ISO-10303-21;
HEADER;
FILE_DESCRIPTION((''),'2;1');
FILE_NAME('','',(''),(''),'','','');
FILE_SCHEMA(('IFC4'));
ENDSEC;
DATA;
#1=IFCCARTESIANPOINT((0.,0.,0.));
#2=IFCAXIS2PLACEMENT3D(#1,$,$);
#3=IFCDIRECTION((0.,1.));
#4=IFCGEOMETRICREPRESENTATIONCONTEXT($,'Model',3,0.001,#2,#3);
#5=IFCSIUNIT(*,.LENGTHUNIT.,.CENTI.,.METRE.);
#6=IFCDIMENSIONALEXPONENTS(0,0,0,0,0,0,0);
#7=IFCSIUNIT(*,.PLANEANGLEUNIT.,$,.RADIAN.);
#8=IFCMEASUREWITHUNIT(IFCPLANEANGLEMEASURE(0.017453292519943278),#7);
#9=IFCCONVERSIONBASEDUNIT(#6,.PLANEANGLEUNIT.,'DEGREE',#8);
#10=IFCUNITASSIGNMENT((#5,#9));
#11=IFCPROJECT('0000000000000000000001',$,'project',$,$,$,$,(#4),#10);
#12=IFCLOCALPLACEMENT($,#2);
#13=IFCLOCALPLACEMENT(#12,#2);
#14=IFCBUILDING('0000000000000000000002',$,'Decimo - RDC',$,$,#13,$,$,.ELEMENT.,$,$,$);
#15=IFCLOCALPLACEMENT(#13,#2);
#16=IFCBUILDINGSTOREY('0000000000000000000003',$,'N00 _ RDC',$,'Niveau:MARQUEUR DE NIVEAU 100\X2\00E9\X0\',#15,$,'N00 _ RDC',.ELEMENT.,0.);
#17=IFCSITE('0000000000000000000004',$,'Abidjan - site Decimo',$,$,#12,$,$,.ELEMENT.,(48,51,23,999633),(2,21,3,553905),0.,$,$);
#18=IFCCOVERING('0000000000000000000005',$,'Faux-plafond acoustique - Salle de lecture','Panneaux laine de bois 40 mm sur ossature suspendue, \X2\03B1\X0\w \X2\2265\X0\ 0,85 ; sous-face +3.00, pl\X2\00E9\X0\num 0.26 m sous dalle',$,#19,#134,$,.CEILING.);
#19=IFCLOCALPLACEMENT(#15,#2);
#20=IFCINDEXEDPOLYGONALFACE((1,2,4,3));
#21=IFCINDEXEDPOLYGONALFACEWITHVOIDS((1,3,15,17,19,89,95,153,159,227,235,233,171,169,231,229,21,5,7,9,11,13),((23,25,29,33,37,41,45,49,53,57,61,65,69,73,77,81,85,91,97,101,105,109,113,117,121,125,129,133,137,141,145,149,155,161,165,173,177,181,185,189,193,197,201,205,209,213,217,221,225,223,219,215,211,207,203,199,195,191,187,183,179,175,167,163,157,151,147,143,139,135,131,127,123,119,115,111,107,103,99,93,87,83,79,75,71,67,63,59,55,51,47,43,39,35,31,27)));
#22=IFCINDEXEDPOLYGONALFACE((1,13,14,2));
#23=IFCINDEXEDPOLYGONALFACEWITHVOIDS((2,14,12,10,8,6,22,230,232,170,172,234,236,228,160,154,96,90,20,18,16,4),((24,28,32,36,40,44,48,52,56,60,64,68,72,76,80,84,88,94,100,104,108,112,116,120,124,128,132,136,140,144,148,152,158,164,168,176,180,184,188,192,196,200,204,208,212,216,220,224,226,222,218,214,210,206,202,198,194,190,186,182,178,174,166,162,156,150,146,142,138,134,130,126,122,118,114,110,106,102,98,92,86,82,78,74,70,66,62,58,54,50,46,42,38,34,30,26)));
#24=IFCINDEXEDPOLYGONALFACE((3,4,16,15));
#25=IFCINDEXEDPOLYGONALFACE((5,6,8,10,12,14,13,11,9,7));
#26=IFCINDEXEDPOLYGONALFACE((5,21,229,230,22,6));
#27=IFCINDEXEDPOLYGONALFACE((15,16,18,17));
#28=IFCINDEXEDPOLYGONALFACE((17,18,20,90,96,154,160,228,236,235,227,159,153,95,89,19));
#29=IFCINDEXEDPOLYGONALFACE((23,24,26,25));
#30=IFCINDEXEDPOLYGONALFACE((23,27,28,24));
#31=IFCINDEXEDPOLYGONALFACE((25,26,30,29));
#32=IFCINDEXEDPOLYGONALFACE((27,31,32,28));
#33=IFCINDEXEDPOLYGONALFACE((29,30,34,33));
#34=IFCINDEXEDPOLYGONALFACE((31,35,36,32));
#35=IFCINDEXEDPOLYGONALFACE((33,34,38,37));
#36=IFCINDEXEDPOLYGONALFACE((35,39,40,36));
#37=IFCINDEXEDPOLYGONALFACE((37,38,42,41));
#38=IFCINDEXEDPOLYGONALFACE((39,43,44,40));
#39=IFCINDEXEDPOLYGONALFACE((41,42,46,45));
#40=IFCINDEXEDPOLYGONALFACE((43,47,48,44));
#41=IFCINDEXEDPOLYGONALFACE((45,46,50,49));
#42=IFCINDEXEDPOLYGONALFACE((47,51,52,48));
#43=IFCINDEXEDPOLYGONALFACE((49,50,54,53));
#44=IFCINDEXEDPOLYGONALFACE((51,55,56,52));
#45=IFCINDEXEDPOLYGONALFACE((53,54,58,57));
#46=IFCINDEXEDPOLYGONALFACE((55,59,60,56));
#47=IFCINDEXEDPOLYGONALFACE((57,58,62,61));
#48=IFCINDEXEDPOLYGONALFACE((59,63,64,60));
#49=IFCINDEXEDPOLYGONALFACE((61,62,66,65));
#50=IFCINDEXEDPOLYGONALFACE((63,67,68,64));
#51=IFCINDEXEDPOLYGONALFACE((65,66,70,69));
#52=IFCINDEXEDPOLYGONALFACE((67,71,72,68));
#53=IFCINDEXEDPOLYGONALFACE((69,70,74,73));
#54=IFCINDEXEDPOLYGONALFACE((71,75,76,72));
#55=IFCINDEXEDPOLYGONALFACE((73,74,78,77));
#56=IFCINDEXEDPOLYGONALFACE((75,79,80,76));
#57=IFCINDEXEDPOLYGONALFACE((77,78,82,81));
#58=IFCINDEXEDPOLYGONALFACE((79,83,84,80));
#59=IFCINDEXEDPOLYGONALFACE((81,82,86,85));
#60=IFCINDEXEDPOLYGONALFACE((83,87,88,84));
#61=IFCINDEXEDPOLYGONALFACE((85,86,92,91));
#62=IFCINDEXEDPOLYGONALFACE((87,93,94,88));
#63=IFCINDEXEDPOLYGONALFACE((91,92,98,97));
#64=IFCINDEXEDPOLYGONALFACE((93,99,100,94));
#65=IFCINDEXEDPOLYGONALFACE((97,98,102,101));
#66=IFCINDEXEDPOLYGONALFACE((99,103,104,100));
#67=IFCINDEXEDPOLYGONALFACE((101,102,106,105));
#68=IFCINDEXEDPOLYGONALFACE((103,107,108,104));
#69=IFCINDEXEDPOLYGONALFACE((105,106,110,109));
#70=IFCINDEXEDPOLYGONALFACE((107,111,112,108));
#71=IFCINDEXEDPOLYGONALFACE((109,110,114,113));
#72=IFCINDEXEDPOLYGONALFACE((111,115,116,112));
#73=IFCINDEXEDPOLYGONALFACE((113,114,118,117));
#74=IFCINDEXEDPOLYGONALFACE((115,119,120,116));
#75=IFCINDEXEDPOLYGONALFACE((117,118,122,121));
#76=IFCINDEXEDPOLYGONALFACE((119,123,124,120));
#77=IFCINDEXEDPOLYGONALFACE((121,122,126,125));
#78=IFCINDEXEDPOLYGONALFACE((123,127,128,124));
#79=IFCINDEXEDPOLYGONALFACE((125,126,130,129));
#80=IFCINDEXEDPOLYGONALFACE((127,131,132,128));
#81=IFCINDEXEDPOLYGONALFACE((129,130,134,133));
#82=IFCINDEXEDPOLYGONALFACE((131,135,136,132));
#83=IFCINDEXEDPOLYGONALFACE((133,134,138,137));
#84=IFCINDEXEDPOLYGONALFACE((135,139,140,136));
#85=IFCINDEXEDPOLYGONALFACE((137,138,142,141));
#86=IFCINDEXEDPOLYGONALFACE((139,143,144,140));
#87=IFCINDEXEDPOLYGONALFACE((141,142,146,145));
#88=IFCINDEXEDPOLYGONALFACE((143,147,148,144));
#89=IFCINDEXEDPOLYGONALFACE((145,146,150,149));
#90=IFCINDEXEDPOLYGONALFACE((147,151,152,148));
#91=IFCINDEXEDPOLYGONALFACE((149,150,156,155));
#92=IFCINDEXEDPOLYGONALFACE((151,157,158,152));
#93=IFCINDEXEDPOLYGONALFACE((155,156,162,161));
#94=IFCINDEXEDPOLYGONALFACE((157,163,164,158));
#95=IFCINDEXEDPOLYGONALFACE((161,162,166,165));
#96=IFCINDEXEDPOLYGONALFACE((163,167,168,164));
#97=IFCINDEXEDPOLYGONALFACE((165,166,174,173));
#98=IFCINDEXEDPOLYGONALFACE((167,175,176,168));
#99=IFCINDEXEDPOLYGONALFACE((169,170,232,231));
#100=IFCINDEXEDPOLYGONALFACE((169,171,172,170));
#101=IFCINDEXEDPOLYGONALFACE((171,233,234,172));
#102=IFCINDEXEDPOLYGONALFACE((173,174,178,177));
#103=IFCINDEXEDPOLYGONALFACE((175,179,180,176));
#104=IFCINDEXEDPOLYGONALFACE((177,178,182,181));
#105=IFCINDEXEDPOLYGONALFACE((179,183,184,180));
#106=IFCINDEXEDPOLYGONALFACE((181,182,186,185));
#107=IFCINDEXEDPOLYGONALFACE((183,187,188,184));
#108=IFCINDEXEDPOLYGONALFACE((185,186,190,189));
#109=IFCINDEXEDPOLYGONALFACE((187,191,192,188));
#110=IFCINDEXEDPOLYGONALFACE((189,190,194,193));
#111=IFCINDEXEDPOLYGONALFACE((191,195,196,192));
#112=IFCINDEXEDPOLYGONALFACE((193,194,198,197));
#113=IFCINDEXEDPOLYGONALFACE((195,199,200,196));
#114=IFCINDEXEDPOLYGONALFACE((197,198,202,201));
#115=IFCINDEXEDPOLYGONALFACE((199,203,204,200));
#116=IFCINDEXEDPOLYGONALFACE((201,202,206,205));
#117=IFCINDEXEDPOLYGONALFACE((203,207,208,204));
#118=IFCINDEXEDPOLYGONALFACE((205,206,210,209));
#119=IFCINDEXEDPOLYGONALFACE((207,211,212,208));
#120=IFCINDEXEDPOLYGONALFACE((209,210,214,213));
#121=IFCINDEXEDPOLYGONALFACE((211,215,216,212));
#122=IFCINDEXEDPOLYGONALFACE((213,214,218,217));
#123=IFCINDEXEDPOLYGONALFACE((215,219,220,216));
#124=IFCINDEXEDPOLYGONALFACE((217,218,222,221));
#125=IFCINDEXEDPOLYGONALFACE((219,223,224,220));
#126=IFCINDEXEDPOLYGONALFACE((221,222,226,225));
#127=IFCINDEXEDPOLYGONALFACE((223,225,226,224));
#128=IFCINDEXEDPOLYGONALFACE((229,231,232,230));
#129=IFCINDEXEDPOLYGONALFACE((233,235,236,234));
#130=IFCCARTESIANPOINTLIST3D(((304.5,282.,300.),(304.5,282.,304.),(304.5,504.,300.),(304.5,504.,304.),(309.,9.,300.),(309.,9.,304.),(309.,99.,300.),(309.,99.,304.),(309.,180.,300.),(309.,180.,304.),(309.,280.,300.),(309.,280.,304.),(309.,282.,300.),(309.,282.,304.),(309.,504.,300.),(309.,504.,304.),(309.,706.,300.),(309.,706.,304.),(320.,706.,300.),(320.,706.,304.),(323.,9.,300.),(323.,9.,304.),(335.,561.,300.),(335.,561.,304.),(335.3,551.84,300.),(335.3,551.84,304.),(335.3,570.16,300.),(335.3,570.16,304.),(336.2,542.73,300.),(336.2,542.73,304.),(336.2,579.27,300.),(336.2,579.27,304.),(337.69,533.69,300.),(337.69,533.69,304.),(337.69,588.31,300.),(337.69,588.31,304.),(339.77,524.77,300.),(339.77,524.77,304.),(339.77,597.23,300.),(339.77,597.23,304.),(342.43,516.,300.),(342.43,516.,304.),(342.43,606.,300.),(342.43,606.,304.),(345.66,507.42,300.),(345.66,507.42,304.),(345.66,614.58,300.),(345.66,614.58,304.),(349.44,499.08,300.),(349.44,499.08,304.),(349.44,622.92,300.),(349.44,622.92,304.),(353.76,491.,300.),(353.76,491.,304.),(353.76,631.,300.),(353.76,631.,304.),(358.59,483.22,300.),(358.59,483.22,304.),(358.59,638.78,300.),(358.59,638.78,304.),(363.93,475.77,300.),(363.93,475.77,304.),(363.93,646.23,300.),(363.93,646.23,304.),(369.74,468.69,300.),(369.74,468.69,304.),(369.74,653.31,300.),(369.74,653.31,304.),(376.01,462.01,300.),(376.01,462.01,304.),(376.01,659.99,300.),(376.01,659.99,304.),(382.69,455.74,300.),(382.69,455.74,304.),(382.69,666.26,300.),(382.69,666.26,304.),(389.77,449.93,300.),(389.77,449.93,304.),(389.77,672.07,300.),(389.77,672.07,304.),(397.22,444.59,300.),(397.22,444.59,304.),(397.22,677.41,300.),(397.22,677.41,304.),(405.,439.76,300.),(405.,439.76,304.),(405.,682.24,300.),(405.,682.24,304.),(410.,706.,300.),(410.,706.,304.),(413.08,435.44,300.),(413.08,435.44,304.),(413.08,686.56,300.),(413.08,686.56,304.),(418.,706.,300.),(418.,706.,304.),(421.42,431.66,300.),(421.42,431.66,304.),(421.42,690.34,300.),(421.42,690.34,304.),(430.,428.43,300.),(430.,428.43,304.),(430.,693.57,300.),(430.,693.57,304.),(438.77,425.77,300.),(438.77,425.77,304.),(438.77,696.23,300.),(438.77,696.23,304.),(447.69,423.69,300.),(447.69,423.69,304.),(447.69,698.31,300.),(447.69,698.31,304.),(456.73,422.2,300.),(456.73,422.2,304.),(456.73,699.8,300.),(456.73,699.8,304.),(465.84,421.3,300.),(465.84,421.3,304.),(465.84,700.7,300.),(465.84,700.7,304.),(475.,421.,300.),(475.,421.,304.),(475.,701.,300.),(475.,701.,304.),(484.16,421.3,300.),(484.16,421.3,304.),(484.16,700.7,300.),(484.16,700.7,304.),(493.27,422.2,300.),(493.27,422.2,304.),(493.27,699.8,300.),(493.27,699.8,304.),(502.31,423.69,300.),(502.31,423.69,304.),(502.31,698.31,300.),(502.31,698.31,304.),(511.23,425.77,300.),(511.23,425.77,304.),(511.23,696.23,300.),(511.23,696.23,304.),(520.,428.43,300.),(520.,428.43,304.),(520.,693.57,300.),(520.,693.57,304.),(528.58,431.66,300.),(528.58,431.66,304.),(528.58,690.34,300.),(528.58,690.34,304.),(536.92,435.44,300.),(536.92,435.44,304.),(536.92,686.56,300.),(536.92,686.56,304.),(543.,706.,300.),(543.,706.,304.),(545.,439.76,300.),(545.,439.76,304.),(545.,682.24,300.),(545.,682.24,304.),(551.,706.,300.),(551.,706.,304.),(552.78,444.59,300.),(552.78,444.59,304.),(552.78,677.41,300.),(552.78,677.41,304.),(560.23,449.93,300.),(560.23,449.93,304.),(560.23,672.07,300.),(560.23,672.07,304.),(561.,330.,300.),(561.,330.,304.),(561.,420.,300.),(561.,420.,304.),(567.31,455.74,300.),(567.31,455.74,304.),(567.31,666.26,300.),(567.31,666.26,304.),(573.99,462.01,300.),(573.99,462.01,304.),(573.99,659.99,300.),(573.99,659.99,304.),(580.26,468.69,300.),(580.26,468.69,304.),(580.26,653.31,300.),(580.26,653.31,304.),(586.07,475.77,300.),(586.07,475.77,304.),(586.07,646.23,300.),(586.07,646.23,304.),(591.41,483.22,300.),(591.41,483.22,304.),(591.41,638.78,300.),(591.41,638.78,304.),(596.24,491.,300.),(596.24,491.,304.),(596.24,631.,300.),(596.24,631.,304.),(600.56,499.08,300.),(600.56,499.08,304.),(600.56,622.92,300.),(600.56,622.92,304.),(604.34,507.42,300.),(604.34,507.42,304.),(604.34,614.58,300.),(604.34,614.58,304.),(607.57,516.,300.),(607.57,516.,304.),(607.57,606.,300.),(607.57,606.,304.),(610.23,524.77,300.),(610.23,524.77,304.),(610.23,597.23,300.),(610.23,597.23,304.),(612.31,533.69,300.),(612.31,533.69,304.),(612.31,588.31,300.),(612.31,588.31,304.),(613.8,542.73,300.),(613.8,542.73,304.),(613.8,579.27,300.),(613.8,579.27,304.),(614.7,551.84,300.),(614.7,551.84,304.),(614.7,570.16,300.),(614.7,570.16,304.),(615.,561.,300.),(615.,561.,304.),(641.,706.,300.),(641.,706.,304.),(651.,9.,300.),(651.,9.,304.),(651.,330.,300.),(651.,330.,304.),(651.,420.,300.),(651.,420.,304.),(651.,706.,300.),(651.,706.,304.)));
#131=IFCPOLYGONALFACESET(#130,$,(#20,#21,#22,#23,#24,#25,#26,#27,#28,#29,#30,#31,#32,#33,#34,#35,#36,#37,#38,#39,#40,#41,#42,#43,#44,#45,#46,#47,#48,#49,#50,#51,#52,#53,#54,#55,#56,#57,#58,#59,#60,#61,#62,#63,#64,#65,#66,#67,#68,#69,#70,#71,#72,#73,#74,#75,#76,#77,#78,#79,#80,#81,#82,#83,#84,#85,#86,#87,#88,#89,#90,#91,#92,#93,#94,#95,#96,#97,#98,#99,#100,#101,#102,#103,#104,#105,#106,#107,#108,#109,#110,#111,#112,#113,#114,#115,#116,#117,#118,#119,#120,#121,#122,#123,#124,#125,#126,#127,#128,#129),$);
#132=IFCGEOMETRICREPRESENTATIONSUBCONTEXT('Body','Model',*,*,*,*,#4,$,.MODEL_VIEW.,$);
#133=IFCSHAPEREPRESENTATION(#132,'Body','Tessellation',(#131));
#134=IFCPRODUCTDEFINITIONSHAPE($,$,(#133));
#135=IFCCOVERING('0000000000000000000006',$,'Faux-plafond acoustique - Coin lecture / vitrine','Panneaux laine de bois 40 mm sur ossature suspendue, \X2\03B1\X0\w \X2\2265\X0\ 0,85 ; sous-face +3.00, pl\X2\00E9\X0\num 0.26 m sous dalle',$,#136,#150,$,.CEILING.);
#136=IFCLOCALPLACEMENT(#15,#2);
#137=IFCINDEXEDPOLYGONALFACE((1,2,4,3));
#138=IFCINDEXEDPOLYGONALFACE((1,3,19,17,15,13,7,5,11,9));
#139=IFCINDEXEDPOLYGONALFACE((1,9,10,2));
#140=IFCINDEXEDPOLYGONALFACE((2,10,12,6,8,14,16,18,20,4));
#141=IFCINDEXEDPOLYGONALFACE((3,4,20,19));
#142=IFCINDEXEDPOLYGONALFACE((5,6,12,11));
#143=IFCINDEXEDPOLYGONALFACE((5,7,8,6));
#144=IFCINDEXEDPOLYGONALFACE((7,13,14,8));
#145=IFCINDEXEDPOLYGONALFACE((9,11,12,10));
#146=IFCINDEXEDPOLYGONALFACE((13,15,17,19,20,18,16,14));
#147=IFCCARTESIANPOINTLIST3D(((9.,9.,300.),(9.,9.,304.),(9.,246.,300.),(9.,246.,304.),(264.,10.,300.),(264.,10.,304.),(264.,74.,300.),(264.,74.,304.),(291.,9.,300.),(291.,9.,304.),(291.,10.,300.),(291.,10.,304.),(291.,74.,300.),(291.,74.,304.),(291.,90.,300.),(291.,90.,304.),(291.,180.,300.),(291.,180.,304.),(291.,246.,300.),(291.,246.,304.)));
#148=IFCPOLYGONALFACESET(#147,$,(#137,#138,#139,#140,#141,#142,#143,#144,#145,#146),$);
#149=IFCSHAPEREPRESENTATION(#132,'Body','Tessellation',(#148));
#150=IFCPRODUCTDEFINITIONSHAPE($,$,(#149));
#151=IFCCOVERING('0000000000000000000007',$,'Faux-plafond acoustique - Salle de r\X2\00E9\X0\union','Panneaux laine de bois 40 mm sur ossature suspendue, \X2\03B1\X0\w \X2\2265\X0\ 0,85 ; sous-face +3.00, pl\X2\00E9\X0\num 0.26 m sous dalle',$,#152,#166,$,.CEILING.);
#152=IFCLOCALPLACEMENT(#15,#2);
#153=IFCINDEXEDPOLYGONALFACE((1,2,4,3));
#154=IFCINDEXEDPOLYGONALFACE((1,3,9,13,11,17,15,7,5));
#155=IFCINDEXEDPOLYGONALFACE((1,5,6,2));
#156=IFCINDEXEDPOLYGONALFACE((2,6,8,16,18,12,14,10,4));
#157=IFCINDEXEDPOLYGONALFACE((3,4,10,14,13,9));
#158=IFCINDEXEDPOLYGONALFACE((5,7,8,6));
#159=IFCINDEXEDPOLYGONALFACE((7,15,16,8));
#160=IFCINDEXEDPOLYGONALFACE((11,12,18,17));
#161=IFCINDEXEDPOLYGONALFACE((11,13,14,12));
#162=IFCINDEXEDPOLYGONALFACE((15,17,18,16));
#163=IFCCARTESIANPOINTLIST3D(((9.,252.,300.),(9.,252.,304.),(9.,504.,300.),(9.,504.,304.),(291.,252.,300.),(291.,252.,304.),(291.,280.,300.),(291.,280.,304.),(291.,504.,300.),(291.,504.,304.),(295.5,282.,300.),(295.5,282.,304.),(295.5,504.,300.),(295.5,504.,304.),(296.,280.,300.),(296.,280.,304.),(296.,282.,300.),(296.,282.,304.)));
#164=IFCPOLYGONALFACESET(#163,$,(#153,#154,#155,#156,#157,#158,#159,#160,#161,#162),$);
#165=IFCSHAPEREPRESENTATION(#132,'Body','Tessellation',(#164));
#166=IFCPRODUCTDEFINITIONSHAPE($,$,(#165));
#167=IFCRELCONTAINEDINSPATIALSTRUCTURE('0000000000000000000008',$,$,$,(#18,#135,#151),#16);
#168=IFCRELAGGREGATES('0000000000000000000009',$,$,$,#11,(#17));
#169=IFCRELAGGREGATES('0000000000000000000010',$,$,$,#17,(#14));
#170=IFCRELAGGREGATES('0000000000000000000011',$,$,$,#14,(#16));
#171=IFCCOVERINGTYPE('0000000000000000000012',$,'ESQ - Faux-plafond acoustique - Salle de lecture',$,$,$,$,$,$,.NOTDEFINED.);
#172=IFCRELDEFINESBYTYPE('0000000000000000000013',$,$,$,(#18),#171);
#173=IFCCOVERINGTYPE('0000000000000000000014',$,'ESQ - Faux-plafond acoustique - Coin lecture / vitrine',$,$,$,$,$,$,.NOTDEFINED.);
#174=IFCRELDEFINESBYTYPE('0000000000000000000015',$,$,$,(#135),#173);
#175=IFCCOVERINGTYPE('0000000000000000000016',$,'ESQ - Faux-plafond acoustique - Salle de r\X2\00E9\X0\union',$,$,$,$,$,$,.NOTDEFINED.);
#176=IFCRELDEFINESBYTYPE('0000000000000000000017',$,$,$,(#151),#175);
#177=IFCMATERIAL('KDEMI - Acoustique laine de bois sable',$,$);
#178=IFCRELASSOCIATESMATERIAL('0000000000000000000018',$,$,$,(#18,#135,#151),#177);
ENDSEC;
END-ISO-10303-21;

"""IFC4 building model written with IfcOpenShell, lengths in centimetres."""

from ifc_helpers import new_model, entity, si_unit, converted_unit, direction, frame, origin, origin_with_axes, place, context, subcontext, project, spatial, polyline, outline, extrude, material, type_object, element, save


model = new_model("IFC4")

# Units and contexts
model_context = context("Model", 3, precision=0.001, world=origin(), true_north=direction((0.0, 1.0)))
body_context = subcontext(model_context, "Body", "Model", "MODEL_VIEW")
ifc_project = project(units=[si_unit("LENGTHUNIT", "METRE", prefix="CENTI"), converted_unit("PLANEANGLEUNIT", "DEGREE", entity("IfcPlaneAngleMeasure", 0.017453292519943278), si_unit("PLANEANGLEUNIT", "RADIAN"), dimensions=[0, 0, 0, 0, 0, 0, 0])], contexts=[model_context])

# Site, building, storey
site_placement = place(None, origin())
site = spatial("IfcSite", under=ifc_project, at=site_placement, Name="Abidjan - site Decimo", CompositionType="ELEMENT", RefLatitude=(48, 51, 23, 999633), RefLongitude=(2, 21, 3, 553905), RefElevation=0.0)
building_placement = place(site_placement, origin())
building = spatial("IfcBuilding", under=site, at=building_placement, Name="Decimo - RDC", CompositionType="ELEMENT")
storey_placement = place(building_placement, origin())
storey = spatial("IfcBuildingStorey", under=building, at=storey_placement, Name="N00 _ RDC", ObjectType="Niveau:MARQUEUR DE NIVEAU 100é", LongName="N00 _ RDC", CompositionType="ELEMENT", Elevation=0.0)

# Coverings
ifc_material_1 = material(Name="KDEMI - Acoustique laine de bois sable")
covering_type_1 = type_object("IfcCoveringType", Name="ESQ - Faux-plafond acoustique - Salle de lecture", PredefinedType="NOTDEFINED")
covering_1_placement = place(storey_placement, origin_with_axes())
element("IfcCovering", 1, at=covering_1_placement, inside=storey, type_object=covering_type_1, material=ifc_material_1, Name="Faux-plafond acoustique - Salle de lecture", Description="Panneaux laine de bois 40 mm sur ossature suspendue, αw ≥ 0,85 ; sous-face +3.00, plénum 0.26 m sous dalle", PredefinedType="CEILING", context=body_context, shape_type="SweptSolid", body=[
    extrude(outline(polyline([(651.0, 706.0), (651.0, 420.0), (561.0, 420.0), (561.0, 330.0), (651.0, 330.0), (651.0, 9.0), (651.0, 9.0), (651.0, 9.0), (323.0, 9.0), (323.0, 9.0), (309.0, 9.0), (309.0, 99.0), (309.0, 180.0), (309.0, 180.0), (309.0, 280.0), (309.0, 280.0), (309.0, 282.0), (304.0, 282.0), (304.0, 282.0), (304.5, 282.0), (304.5, 504.0), (309.0, 504.0), (309.0, 504.0), (309.0, 706.0), (320.0, 706.0), (410.0, 706.0), (418.0, 706.0), (543.0, 706.0), (551.0, 706.0), (641.0, 706.0), (651.0, 706.0)]), holes=[polyline([(610.23, 597.23), (607.57, 606.0), (604.34, 614.58), (600.56, 622.92), (596.24, 631.0), (591.41, 638.78), (586.07, 646.23), (580.26, 653.31), (573.99, 659.99), (567.31, 666.26), (560.23, 672.07), (552.78, 677.41), (545.0, 682.24), (536.92, 686.56), (528.58, 690.34), (520.0, 693.57), (511.23, 696.23), (502.31, 698.31), (493.27, 699.8), (484.16, 700.7), (475.0, 701.0), (465.84, 700.7), (456.73, 699.8), (447.69, 698.31), (438.77, 696.23), (430.0, 693.57), (421.42, 690.34), (413.08, 686.56), (405.0, 682.24), (397.22, 677.41), (389.77, 672.07), (382.69, 666.26), (376.01, 659.99), (369.74, 653.31), (363.93, 646.23), (358.59, 638.78), (353.76, 631.0), (349.44, 622.92), (345.66, 614.58), (342.43, 606.0), (339.77, 597.23), (337.69, 588.31), (336.2, 579.27), (335.3, 570.16), (335.0, 561.0), (335.3, 551.84), (336.2, 542.73), (337.69, 533.69), (339.77, 524.77), (342.43, 516.0), (345.66, 507.42), (349.44, 499.08), (353.76, 491.0), (358.59, 483.22), (363.93, 475.77), (369.74, 468.69), (376.01, 462.01), (382.69, 455.74), (389.77, 449.93), (397.22, 444.59), (405.0, 439.76), (413.08, 435.44), (421.42, 431.66), (430.0, 428.43), (438.77, 425.77), (447.69, 423.69), (456.73, 422.2), (465.84, 421.3), (475.0, 421.0), (484.16, 421.3), (493.27, 422.2), (502.31, 423.69), (511.23, 425.77), (520.0, 428.43), (528.58, 431.66), (536.92, 435.44), (545.0, 439.76), (552.78, 444.59), (560.23, 449.93), (567.31, 455.74), (573.99, 462.01), (580.26, 468.69), (586.07, 475.77), (591.41, 483.22), (596.24, 491.0), (600.56, 499.08), (604.34, 507.42), (607.57, 516.0), (610.23, 524.77), (612.31, 533.69), (613.8, 542.73), (614.7, 551.84), (615.0, 561.0), (614.7, 570.16), (613.8, 579.27), (612.31, 588.31), (610.23, 597.23)])]), frame((0.0, 0.0, 300.0)), (0.0, 0.0, 1.0), 4.0),
])
covering_type_2 = type_object("IfcCoveringType", Name="ESQ - Faux-plafond acoustique - Coin lecture / vitrine", PredefinedType="NOTDEFINED")
covering_2_placement = place(storey_placement, origin_with_axes())
element("IfcCovering", 2, at=covering_2_placement, inside=storey, type_object=covering_type_2, material=ifc_material_1, Name="Faux-plafond acoustique - Coin lecture / vitrine", Description="Panneaux laine de bois 40 mm sur ossature suspendue, αw ≥ 0,85 ; sous-face +3.00, plénum 0.26 m sous dalle", PredefinedType="CEILING", context=body_context, shape_type="SweptSolid", body=[
    extrude(outline(polyline([(291.0, 90.0), (291.0, 74.0), (264.0, 74.0), (264.0, 10.0), (291.0, 10.0), (291.0, 9.0), (9.0, 9.0), (9.0, 246.0), (291.0, 246.0), (291.0, 180.0), (291.0, 180.0), (291.0, 90.0), (291.0, 90.0)])), frame((0.0, 0.0, 300.0)), (0.0, 0.0, 1.0), 4.0),
])
covering_type_3 = type_object("IfcCoveringType", Name="ESQ - Faux-plafond acoustique - Salle de réunion", PredefinedType="NOTDEFINED")
covering_3_placement = place(storey_placement, origin_with_axes())
element("IfcCovering", 3, at=covering_3_placement, inside=storey, type_object=covering_type_3, material=ifc_material_1, Name="Faux-plafond acoustique - Salle de réunion", Description="Panneaux laine de bois 40 mm sur ossature suspendue, αw ≥ 0,85 ; sous-face +3.00, plénum 0.26 m sous dalle", PredefinedType="CEILING", context=body_context, shape_type="SweptSolid", body=[
    extrude(outline(polyline([(296.0, 280.0), (291.0, 280.0), (291.0, 252.0), (9.0, 252.0), (9.0, 504.0), (291.0, 504.0), (295.5, 504.0), (295.5, 282.0), (296.0, 282.0), (296.0, 280.0)])), frame((0.0, 0.0, 300.0)), (0.0, 0.0, 1.0), 4.0),
])

save(model, "model.ifc")
